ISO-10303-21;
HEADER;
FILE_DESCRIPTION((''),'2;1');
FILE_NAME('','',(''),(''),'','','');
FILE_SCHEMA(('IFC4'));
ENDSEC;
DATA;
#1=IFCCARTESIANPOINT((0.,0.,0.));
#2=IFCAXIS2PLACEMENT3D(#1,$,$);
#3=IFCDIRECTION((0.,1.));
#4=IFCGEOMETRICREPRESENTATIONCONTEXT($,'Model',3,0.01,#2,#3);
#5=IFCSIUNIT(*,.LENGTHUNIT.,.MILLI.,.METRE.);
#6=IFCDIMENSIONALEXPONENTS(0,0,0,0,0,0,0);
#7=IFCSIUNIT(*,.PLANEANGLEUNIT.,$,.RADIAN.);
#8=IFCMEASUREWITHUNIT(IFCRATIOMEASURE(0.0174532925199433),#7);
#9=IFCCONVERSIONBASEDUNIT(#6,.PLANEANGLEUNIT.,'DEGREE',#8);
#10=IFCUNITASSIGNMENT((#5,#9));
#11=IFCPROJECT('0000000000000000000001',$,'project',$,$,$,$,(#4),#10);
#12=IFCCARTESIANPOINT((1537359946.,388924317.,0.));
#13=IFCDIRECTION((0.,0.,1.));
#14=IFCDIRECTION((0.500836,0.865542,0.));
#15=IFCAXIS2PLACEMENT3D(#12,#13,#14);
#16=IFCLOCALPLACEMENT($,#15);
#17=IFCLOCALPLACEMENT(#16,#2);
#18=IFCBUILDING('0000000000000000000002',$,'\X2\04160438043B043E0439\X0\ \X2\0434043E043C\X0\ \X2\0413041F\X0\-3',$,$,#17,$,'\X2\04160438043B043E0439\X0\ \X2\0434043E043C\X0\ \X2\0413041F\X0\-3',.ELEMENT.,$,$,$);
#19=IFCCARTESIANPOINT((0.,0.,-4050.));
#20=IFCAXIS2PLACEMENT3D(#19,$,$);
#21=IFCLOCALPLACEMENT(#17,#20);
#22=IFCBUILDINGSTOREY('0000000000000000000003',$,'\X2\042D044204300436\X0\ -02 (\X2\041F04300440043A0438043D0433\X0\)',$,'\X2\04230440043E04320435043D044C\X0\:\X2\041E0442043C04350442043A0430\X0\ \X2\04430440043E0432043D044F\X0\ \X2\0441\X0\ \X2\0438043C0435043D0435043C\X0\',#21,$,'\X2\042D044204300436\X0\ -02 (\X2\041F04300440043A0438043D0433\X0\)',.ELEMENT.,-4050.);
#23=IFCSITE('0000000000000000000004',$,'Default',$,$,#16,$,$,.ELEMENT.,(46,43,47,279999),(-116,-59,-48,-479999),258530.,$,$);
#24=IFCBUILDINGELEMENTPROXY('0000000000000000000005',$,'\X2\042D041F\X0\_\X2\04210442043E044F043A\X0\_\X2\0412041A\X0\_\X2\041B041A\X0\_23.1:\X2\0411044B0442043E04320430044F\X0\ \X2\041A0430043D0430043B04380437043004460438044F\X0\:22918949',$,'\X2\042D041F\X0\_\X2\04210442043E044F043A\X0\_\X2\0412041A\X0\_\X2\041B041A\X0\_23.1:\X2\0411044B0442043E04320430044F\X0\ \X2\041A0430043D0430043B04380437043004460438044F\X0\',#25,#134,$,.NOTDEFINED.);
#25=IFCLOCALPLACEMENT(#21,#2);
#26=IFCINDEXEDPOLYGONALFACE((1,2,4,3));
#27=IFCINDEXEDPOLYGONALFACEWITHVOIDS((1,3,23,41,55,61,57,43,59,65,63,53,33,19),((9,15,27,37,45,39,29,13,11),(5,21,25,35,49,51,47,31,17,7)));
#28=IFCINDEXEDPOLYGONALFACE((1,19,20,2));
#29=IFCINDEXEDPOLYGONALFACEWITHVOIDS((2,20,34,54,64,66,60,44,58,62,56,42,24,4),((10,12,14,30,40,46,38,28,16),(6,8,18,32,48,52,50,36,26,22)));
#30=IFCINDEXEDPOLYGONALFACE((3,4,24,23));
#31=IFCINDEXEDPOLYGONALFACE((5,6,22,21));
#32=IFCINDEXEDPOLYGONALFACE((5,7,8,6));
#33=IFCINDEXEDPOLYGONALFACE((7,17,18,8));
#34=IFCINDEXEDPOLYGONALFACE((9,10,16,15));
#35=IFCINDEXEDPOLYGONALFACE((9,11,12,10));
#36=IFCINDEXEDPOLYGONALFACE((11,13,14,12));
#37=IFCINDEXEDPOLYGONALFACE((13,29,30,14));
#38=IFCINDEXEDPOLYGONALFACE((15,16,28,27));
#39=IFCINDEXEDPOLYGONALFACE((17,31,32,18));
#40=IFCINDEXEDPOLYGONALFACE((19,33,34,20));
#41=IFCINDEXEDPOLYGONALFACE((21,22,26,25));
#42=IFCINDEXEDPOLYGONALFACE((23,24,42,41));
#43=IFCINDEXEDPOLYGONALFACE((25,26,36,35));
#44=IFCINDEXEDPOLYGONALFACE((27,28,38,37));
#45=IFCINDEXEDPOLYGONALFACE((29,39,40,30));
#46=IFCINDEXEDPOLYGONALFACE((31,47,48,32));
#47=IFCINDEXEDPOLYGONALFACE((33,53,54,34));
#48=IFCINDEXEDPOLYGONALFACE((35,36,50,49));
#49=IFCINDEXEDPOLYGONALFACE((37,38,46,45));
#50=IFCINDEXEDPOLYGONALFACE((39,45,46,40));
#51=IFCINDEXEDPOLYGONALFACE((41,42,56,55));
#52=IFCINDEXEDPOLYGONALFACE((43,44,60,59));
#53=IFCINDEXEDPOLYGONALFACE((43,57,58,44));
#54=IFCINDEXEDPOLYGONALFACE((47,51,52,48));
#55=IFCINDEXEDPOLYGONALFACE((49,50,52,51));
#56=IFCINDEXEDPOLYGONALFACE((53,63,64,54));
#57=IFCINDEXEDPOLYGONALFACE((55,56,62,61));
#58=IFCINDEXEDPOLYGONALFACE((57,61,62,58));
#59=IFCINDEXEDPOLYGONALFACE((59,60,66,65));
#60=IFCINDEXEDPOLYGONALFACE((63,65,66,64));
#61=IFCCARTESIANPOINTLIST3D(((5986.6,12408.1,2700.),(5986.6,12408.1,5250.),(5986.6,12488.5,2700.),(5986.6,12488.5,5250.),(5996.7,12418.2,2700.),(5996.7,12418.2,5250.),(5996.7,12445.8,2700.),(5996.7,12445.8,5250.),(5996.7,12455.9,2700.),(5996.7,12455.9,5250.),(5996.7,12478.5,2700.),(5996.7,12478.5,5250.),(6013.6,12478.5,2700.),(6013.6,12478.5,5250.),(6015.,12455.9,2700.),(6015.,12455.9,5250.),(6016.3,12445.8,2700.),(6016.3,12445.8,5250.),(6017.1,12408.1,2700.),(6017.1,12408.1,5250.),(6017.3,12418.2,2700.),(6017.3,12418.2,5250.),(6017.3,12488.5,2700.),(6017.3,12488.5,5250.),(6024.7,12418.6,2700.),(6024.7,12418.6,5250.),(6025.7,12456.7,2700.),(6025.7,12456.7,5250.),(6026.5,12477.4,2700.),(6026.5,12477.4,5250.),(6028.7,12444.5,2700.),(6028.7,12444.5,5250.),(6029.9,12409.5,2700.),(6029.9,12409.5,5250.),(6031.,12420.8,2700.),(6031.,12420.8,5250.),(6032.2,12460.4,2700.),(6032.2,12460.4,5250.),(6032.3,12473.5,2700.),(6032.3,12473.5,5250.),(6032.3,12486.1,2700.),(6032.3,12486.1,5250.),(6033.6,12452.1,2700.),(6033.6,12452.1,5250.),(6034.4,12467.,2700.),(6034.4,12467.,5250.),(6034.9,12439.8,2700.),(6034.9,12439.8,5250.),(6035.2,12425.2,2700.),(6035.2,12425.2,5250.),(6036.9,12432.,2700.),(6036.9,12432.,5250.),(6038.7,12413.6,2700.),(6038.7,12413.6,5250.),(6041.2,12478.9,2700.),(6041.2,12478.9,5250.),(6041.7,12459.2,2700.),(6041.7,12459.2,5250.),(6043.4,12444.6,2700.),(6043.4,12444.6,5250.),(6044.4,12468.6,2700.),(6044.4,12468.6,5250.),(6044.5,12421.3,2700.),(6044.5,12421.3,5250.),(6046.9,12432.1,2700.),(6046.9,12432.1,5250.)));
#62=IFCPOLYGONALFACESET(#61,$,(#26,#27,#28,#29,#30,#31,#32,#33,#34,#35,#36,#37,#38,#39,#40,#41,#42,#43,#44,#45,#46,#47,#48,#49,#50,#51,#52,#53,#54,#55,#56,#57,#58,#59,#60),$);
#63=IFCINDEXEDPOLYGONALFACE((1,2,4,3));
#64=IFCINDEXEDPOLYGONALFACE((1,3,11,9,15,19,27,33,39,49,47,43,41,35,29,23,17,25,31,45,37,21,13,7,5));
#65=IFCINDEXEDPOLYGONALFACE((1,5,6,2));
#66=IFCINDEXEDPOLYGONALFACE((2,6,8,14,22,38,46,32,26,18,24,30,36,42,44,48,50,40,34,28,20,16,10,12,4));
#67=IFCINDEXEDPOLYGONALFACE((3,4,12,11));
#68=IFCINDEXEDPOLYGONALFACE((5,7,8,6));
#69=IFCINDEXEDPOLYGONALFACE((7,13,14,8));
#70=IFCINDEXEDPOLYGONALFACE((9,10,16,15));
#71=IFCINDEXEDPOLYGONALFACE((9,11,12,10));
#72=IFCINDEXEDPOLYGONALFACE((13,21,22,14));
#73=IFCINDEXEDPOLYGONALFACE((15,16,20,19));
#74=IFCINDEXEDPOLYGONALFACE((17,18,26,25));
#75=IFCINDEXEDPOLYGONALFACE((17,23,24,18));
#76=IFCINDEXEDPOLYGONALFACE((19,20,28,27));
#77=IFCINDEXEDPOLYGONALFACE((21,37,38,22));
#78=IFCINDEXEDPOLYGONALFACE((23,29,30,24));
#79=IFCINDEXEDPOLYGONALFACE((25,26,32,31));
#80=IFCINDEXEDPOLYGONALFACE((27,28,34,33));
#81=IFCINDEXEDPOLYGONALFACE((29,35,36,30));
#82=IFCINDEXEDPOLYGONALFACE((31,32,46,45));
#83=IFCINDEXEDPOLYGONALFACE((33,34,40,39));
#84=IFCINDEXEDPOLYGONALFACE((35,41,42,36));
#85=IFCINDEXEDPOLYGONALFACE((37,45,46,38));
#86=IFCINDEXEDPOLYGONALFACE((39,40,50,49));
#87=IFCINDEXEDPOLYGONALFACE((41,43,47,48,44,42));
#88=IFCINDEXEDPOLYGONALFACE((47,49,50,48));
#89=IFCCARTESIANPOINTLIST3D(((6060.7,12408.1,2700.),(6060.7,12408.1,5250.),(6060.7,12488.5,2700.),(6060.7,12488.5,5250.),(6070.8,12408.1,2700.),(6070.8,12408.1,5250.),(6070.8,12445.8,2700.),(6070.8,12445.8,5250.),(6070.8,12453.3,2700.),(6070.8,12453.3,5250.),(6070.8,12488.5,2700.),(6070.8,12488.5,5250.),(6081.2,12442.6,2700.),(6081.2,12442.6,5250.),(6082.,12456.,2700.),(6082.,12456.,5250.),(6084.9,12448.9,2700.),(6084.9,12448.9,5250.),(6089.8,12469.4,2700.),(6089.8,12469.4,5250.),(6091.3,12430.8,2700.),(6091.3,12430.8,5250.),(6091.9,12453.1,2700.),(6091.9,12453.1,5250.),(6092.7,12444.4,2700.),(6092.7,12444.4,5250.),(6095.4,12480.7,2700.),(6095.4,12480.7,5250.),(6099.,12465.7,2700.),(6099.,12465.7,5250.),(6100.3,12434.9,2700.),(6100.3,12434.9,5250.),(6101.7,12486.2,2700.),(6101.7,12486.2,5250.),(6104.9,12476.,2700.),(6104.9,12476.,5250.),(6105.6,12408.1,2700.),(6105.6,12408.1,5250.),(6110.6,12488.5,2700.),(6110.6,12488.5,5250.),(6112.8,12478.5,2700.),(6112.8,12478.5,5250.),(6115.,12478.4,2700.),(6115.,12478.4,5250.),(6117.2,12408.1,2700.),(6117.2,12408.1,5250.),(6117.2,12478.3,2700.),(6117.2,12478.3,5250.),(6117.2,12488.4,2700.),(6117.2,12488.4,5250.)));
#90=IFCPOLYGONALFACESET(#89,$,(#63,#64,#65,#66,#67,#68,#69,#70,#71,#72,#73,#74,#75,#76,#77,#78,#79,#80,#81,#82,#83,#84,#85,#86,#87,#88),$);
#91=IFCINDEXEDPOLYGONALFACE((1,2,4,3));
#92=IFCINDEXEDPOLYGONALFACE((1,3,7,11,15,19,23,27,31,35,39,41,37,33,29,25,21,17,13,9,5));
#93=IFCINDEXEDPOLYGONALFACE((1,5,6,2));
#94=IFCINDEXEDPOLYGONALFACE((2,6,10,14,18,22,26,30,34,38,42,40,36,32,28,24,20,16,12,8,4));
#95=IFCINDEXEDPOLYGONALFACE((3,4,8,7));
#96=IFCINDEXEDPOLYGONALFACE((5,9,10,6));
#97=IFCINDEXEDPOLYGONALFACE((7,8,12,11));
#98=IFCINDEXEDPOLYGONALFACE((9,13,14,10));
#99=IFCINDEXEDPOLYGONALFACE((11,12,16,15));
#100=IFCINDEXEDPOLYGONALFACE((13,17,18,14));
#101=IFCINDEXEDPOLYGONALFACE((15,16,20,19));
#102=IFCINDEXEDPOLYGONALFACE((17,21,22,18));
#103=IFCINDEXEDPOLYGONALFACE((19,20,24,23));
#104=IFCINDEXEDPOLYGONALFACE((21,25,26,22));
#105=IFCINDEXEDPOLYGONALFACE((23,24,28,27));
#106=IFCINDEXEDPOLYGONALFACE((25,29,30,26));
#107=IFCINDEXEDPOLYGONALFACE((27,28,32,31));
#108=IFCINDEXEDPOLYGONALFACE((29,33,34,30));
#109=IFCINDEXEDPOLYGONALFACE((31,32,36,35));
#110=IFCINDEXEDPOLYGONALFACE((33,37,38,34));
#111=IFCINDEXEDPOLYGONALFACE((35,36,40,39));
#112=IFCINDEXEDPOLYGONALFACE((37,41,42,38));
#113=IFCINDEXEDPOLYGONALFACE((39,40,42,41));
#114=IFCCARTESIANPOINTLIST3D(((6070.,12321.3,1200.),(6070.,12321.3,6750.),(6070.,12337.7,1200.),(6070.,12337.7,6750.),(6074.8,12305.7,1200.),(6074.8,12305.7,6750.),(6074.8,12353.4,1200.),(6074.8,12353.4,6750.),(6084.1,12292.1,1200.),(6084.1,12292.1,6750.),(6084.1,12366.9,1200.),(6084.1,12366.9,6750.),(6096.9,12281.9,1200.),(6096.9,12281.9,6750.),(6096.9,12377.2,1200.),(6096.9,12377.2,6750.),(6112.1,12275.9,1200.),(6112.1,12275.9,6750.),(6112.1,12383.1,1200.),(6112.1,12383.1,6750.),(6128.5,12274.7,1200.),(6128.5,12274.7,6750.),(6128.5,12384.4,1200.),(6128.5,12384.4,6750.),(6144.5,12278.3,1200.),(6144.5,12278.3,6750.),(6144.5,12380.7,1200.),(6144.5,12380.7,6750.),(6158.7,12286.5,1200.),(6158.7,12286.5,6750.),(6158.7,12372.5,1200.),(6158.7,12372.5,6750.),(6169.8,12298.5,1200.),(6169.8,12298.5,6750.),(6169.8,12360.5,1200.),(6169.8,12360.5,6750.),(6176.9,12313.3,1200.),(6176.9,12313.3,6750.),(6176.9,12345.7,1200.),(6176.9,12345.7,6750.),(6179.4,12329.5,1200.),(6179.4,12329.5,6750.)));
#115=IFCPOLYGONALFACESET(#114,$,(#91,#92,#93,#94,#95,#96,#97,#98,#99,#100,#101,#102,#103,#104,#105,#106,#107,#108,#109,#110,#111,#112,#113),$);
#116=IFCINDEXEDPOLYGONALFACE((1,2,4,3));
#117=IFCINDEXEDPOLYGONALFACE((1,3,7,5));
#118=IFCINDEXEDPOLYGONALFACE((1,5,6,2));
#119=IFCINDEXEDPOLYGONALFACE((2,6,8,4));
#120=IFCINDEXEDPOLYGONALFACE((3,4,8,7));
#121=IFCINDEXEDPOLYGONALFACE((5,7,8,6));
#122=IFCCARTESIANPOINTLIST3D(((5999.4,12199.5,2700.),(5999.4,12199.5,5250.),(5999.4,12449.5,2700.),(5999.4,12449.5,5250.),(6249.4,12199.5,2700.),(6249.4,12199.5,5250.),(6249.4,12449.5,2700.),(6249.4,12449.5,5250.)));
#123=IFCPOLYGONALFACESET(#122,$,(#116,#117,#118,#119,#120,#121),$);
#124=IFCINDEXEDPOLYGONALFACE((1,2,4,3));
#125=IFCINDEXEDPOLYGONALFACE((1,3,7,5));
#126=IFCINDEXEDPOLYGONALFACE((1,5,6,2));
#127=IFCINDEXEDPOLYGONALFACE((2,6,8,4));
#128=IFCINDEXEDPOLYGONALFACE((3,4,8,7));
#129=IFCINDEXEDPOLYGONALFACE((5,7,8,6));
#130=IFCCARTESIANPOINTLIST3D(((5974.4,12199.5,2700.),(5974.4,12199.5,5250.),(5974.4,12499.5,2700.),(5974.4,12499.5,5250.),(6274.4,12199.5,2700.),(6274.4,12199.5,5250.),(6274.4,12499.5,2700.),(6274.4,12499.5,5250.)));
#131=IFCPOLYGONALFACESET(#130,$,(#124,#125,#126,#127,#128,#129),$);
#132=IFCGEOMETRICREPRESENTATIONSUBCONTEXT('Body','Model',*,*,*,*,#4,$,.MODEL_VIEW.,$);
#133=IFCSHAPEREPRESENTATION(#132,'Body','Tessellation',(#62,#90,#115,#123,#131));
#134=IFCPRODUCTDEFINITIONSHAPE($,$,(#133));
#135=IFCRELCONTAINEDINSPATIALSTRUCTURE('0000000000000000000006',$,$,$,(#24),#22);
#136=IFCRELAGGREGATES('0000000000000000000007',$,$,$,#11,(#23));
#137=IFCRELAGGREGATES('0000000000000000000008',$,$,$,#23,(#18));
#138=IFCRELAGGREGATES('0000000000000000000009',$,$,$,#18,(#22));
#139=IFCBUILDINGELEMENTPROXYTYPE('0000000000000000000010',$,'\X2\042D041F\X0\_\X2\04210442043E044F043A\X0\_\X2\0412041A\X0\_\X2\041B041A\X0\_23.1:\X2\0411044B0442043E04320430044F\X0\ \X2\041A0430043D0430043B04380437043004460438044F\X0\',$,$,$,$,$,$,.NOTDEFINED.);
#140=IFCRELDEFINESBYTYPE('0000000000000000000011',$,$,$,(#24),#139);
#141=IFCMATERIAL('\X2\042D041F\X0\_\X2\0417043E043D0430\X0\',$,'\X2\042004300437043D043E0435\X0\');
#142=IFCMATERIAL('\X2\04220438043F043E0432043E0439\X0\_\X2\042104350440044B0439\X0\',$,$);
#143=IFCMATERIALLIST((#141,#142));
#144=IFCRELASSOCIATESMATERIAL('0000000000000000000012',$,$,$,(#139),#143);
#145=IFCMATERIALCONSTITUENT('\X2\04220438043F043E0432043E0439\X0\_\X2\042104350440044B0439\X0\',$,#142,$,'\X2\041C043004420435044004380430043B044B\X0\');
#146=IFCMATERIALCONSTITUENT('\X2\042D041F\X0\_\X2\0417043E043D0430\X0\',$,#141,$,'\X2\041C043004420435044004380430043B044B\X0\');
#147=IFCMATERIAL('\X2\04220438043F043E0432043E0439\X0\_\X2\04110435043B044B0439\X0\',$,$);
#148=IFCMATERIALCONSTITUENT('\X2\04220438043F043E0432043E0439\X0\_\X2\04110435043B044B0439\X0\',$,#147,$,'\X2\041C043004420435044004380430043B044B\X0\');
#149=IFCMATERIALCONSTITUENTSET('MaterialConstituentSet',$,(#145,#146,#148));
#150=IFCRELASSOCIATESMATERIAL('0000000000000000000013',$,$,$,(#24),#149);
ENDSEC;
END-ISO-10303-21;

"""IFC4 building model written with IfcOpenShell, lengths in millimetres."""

from ifc_helpers import new_model, entity, si_unit, converted_unit, direction, frame, frame_2d, origin, place, context, subcontext, project, spatial, polyline, rectangle, circle, outline, extrude, source, transform, mapped, material, material_list, constituent, constituent_set, type_object, type_shapes, element, save


model = new_model("IFC4")

# Units and contexts
model_context = context("Model", 3, precision=0.01, world=origin(), true_north=direction((0.0, 1.0)))
body_context = subcontext(model_context, "Body", "Model", "MODEL_VIEW")
ifc_project = project(units=[si_unit("LENGTHUNIT", "METRE", prefix="MILLI"), converted_unit("PLANEANGLEUNIT", "DEGREE", entity("IfcRatioMeasure", 0.0174532925199433), si_unit("PLANEANGLEUNIT", "RADIAN"), dimensions=[0, 0, 0, 0, 0, 0, 0])], contexts=[model_context])

# Site, building, storey
site_placement = place(None, frame((1537359946.0, 388924317.0, 0.0), z_axis=(0.0, 0.0, 1.0), x_axis=(0.500836, 0.865542, 0.0)))
site = spatial("IfcSite", under=ifc_project, at=site_placement, Name="Default", CompositionType="ELEMENT", RefLatitude=(46, 43, 47, 279999), RefLongitude=(-116, -59, -48, -479999), RefElevation=258530.0)
building_placement = place(site_placement, origin())
building = spatial("IfcBuilding", under=site, at=building_placement, Name="Жилой дом ГП-3", LongName="Жилой дом ГП-3", CompositionType="ELEMENT")
storey_placement = place(building_placement, frame((0.0, 0.0, -4050.0)))
storey = spatial("IfcBuildingStorey", under=building, at=storey_placement, Name="Этаж -02 (Паркинг)", ObjectType="Уровень:Отметка уровня с именем", LongName="Этаж -02 (Паркинг)", CompositionType="ELEMENT", Elevation=-4050.0)

# Building element proxy
ifc_material_1 = material(Name="ЭП_Зона", Category="Разное")
ifc_material_2 = material(Name="Типовой_Белый")
ifc_material_3 = material(Name="Типовой_Серый")
ifc_material_list_1 = material_list([ifc_material_1, ifc_material_3])
building_element_proxy_type_1 = type_object("IfcBuildingElementProxyType", Name="ЭП_Стояк_ВК_ЛК_23.1:Бытовая Канализация", PredefinedType="NOTDEFINED", material=ifc_material_list_1)
shared_shape_1 = source(origin(), body_context, "Body", "SweptSolid", [
    extrude(outline(polyline([(-42.2, -39.0), (-11.8, -39.0), (1.1, -37.6), (9.8, -33.5), (15.7, -25.8), (18.0, -15.0), (14.6, -2.5), (4.7, 5.0), (12.8, 12.1), (15.5, 21.5), (12.3, 31.8), (3.4, 39.0), (-11.6, 41.4), (-42.2, 41.4), (-42.2, -39.0)]), holes=[polyline([(-32.2, 8.8), (-32.2, 31.4), (-15.2, 31.4), (-2.3, 30.3), (3.5, 26.4), (5.5, 19.9), (3.3, 13.3), (-3.1, 9.6), (-13.9, 8.8), (-32.2, 8.8)]), polyline([(-32.2, -28.9), (-32.2, -1.3), (-12.6, -1.3), (-0.2, -2.6), (6.1, -7.3), (8.0, -15.1), (6.3, -21.9), (2.2, -26.3), (-4.1, -28.5), (-11.6, -28.9), (-32.2, -28.9)])]), frame((54.5, -52.4, -1350.0)), (0.0, 0.0, 1.0), 2550.0),
    extrude(outline(polyline([(-32.1, -31.9), (48.3, -31.9), (48.3, -21.8), (10.6, -21.8), (13.8, -11.4), (25.6, -1.3), (48.3, 13.0), (48.3, 24.6), (21.4, 7.7), (12.0, 0.1), (7.4, -7.7), (3.3, -0.7), (-9.3, 6.4), (-19.7, 12.3), (-22.1, 20.2), (-22.0, 22.4), (-22.0, 24.6), (-32.0, 24.6), (-32.1, 18.0), (-29.9, 9.0), (-24.3, 2.8), (-13.1, -2.8), (0.4, -10.6), (3.0, -21.8), (-32.1, -21.8), (-32.1, -31.9)])), frame((118.2, -43.1, -1350.0), z_axis=(0.0, 0.0, 1.0), x_axis=(0.0, -1.0, 0.0)), (0.0, 0.0, 1.0), 2550.0),
    extrude(circle(Radius=55.0, at=frame_2d((0.0, 0.0), x_axis=(1.0, 0.0))), frame((150.0, -170.0, -2850.0)), (0.0, 0.0, 1.0), 5550.0),
    extrude(rectangle(XDim=250.0, YDim=250.0, at=frame_2d((0.0, 0.0), x_axis=(1.0, 0.0))), frame((150.0, -175.0, -1350.0)), (0.0, 0.0, 1.0), 2550.0),
    extrude(rectangle(XDim=300.0, YDim=300.0, at=frame_2d((0.0, 0.0), x_axis=(1.0, 0.0))), frame((150.0, -150.0, -1350.0)), (0.0, 0.0, 1.0), 2550.0),
])
type_shapes(building_element_proxy_type_1, [shared_shape_1])
ifc_constituent_1 = constituent(ifc_material_3, Name="Типовой_Серый", Category="Материалы")
ifc_constituent_2 = constituent(ifc_material_1, Name="ЭП_Зона", Category="Материалы")
ifc_constituent_3 = constituent(ifc_material_2, Name="Типовой_Белый", Category="Материалы")
ifc_constituent_set_1 = constituent_set(constituents=[ifc_constituent_1, ifc_constituent_2, ifc_constituent_3], Name="MaterialConstituentSet")
proxy_1_placement = place(storey_placement, frame((5974.4, 12499.5, 4050.0)))
element("IfcBuildingElementProxy", 1, at=proxy_1_placement, inside=storey, type_object=building_element_proxy_type_1, material=ifc_constituent_set_1, Name="ЭП_Стояк_ВК_ЛК_23.1:Бытовая Канализация:22918949", ObjectType="ЭП_Стояк_ВК_ЛК_23.1:Бытовая Канализация", PredefinedType="NOTDEFINED", context=body_context, shape_type="MappedRepresentation", body=[
    mapped(shared_shape_1, transform((0.0, 0.0, 0.0), scale=1.0)),
])

save(model, "model.ifc")
